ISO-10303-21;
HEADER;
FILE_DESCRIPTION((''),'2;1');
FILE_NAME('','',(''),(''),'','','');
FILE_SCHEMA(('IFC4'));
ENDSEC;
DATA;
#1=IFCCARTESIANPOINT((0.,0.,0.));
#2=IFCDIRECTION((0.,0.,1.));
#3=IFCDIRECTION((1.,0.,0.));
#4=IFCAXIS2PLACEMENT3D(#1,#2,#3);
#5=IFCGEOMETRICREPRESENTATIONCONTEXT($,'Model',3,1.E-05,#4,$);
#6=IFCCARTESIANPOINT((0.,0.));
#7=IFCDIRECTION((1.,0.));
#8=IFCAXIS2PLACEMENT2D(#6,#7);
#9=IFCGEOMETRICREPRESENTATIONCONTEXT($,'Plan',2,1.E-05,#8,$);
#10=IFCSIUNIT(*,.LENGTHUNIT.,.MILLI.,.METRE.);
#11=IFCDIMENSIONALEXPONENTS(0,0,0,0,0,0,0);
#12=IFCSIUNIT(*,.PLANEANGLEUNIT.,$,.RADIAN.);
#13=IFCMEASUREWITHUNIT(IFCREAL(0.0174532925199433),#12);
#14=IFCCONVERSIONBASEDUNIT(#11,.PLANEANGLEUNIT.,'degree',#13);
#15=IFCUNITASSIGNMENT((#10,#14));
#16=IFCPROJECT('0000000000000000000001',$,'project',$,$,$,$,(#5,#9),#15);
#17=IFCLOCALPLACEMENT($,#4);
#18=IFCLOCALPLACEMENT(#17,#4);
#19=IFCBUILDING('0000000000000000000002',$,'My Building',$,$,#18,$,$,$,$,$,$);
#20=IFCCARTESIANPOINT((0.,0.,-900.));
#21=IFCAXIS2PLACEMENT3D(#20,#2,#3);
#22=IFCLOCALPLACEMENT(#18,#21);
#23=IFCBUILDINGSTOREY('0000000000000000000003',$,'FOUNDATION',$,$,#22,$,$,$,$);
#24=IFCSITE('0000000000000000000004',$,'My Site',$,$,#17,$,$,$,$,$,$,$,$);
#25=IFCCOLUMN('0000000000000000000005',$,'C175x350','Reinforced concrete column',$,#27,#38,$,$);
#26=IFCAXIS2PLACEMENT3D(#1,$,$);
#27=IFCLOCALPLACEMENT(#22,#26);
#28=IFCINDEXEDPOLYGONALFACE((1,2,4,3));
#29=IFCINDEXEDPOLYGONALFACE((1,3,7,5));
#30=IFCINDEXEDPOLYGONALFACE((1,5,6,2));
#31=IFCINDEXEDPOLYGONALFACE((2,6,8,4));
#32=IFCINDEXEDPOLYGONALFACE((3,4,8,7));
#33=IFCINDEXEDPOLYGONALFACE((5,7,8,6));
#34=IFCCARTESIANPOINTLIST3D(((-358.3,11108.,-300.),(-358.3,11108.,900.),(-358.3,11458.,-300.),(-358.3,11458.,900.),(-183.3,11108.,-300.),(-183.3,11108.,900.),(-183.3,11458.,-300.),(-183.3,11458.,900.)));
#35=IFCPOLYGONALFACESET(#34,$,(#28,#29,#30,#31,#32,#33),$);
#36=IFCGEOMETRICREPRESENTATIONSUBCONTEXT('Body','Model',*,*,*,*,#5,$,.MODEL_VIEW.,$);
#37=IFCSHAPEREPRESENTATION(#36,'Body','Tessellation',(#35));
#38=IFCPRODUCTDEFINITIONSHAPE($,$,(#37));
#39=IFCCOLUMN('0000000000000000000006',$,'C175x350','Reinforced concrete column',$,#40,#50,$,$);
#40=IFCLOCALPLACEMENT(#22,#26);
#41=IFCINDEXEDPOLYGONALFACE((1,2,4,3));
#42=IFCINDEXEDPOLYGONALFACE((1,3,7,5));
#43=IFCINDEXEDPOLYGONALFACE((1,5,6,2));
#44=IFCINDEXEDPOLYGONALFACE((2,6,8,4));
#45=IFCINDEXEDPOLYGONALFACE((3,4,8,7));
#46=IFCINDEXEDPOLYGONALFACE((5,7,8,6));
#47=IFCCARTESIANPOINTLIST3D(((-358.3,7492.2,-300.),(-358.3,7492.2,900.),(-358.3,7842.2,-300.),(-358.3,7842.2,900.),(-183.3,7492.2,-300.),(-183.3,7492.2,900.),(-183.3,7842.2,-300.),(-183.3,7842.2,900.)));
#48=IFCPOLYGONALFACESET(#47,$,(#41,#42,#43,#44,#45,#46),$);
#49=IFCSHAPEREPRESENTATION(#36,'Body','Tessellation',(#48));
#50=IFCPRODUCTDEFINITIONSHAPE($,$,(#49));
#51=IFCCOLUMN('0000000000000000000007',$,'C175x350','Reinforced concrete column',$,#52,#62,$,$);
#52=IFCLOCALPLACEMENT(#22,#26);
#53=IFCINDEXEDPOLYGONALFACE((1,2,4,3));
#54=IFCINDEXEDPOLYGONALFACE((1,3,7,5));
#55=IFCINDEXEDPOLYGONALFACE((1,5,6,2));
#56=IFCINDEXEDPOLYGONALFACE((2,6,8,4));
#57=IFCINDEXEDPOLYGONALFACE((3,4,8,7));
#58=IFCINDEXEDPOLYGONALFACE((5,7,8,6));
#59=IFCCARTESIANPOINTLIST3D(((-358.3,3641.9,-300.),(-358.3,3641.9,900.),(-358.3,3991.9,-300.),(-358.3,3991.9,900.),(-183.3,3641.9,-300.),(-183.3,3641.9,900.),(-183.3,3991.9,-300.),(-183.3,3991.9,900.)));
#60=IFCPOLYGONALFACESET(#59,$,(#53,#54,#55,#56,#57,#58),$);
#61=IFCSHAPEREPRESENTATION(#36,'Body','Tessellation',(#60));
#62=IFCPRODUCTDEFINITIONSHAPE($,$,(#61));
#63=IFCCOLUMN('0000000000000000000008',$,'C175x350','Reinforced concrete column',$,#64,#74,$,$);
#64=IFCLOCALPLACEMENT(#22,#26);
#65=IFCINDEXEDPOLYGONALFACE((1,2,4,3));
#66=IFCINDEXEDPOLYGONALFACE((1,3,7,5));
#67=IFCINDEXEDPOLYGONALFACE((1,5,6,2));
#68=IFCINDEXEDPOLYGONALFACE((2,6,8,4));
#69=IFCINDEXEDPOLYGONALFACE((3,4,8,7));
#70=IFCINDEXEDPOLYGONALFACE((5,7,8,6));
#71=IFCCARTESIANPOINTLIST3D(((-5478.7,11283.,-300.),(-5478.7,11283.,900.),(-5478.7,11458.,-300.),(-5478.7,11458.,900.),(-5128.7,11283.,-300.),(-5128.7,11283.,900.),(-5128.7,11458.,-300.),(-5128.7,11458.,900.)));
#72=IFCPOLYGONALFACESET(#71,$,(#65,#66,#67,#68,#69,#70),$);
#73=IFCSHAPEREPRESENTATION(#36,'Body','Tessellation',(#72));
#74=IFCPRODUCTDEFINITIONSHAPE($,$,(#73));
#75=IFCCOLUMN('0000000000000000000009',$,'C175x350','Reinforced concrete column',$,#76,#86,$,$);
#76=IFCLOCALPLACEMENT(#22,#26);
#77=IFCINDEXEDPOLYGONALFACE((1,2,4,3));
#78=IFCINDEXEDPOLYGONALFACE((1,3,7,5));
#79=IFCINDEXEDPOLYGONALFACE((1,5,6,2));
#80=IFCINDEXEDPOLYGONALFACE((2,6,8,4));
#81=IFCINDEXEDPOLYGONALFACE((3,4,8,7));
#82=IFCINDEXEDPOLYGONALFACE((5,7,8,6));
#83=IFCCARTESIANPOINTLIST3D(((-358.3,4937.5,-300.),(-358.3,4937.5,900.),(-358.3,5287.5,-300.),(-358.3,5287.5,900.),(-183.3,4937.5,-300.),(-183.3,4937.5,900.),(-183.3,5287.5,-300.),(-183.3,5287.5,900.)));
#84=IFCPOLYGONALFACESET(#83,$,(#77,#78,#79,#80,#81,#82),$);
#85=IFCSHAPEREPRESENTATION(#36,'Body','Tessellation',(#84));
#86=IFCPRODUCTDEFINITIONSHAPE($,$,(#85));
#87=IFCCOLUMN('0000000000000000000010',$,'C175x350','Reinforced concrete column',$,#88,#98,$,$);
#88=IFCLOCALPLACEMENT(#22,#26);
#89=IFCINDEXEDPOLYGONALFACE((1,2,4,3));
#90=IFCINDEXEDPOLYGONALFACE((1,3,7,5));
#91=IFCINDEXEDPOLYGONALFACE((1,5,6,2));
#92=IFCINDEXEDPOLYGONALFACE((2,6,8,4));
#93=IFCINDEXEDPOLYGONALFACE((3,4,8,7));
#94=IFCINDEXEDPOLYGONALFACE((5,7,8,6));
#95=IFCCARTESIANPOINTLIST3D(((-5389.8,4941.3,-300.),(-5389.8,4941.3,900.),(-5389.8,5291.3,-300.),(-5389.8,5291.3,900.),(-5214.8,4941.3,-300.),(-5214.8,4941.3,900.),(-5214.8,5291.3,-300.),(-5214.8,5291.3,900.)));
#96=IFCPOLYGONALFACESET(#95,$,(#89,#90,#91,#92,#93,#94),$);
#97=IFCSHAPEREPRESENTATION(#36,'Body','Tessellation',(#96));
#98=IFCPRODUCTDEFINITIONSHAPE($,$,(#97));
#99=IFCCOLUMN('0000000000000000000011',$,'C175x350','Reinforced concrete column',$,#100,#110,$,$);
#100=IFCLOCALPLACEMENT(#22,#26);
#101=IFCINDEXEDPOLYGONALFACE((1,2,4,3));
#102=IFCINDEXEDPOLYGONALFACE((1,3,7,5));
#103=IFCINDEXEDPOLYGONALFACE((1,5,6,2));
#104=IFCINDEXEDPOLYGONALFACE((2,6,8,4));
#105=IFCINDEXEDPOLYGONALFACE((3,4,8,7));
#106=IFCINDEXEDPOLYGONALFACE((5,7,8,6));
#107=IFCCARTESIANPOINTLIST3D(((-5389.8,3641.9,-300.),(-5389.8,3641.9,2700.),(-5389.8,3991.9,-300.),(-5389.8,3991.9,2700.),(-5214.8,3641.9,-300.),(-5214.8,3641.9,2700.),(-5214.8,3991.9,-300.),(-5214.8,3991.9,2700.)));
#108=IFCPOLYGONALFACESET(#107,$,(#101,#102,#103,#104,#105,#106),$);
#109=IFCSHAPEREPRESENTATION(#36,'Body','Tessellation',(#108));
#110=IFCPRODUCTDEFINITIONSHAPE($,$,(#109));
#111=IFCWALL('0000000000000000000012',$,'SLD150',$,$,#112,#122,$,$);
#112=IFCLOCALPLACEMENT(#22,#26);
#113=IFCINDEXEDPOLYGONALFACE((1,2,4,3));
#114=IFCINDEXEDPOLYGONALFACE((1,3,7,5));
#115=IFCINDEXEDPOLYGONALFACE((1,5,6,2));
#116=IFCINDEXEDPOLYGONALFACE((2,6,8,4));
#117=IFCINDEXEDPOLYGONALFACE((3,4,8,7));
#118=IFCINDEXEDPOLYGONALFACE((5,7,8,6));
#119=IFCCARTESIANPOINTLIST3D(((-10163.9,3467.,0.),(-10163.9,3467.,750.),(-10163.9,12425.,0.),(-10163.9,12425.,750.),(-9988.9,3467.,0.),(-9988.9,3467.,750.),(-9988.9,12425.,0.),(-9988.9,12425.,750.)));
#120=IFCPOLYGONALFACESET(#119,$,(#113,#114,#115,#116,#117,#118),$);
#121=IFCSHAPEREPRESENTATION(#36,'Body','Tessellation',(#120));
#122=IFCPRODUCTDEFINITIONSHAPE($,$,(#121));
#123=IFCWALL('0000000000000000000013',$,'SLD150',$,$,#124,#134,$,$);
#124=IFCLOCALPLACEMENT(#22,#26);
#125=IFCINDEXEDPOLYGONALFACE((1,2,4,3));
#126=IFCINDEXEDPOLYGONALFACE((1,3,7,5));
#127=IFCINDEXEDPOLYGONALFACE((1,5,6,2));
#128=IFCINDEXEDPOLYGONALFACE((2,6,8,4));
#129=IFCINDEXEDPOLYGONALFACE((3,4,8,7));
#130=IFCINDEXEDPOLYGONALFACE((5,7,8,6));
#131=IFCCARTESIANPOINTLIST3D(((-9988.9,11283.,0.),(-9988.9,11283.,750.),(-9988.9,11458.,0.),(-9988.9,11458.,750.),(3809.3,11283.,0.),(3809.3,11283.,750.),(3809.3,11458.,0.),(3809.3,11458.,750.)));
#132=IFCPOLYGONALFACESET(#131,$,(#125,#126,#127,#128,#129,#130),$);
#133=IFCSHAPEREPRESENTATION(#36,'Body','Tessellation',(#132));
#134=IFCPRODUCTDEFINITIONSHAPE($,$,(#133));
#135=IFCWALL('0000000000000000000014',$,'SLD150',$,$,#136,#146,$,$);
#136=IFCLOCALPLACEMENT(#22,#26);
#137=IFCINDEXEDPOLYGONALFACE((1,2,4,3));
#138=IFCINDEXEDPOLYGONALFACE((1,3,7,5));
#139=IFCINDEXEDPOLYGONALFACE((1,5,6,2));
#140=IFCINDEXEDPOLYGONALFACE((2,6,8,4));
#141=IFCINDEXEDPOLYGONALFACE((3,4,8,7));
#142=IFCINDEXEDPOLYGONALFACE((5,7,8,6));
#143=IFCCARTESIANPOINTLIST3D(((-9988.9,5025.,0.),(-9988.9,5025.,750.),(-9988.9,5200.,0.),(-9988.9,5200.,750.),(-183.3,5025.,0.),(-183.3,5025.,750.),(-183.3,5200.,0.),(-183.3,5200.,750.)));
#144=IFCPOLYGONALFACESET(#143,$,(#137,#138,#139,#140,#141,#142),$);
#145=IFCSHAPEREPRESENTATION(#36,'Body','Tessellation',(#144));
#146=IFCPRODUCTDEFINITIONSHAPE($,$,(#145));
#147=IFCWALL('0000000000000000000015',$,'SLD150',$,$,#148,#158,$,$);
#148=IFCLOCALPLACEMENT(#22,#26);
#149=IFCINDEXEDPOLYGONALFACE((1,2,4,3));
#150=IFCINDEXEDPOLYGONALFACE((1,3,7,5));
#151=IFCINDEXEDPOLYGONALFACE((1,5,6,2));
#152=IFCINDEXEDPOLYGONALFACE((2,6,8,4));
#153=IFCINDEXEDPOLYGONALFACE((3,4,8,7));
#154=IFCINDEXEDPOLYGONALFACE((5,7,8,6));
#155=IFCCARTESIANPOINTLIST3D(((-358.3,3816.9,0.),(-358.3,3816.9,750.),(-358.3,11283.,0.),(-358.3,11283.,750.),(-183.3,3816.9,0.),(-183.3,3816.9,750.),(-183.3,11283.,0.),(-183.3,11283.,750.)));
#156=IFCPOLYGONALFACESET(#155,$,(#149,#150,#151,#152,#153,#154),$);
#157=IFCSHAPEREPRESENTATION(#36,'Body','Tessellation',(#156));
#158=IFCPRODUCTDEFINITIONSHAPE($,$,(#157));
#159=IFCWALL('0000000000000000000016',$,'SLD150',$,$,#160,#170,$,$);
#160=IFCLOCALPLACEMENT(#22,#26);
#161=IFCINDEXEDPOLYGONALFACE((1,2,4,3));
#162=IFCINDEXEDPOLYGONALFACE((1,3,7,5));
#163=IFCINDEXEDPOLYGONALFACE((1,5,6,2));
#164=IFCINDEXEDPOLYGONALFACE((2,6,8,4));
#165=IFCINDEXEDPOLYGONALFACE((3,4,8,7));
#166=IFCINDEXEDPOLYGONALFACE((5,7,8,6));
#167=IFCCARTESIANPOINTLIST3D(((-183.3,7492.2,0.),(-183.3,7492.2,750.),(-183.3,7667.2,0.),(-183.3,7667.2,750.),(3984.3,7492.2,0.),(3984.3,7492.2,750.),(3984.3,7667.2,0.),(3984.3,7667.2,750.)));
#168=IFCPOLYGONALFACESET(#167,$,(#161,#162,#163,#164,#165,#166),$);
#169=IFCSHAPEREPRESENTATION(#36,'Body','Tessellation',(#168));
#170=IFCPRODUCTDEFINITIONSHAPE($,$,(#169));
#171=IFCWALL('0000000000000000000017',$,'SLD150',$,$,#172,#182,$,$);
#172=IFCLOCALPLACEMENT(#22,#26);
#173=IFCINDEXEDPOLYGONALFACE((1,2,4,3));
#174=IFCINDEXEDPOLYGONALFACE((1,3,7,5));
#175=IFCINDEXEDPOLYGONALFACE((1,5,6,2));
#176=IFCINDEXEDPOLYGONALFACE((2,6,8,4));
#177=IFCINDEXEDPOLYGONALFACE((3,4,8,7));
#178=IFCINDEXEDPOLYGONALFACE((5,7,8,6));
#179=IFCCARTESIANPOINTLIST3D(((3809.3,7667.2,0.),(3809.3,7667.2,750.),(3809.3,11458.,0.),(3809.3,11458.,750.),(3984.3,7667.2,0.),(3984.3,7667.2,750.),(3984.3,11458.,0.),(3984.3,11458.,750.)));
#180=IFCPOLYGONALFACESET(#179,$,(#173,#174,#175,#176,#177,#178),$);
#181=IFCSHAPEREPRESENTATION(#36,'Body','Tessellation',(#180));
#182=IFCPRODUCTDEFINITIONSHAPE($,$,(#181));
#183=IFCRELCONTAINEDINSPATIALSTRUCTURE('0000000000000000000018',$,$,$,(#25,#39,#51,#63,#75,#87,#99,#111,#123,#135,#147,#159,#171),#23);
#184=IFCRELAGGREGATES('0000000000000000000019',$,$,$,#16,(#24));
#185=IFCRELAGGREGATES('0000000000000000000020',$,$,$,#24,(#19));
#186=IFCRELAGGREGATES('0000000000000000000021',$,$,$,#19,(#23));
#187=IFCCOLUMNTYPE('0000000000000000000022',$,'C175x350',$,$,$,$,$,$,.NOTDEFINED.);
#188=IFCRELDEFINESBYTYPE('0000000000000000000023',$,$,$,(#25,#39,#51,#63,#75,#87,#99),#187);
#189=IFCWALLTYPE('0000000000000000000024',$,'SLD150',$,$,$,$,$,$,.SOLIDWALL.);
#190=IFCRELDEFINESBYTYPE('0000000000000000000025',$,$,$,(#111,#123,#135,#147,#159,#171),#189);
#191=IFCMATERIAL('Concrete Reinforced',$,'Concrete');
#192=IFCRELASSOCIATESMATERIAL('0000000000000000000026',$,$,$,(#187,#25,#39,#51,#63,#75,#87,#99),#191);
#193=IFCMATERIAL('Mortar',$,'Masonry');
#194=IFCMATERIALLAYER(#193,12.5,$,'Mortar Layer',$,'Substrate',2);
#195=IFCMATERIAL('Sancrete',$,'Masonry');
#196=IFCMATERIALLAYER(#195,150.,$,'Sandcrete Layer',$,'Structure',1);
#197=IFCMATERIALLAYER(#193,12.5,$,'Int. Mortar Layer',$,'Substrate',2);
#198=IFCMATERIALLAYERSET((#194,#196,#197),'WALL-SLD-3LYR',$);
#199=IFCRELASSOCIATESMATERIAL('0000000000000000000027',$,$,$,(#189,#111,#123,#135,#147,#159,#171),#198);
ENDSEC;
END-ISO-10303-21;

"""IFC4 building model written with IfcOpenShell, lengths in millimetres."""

from ifc_helpers import new_model, entity, si_unit, converted_unit, frame, origin_with_axes, origin_2d_with_axis, place, context, subcontext, project, spatial, indexed_curve, rectangle, outline, extrude, material, layer, layer_set, layer_usage, material_profile, profile_set, profile_usage, type_object, element, save


model = new_model("IFC4")

# Units and contexts
model_context = context("Model", 3, precision=1e-05, world=origin_with_axes())
plan_context = context("Plan", 2, precision=1e-05, world=origin_2d_with_axis())
body_context = subcontext(model_context, "Body", "Model", "MODEL_VIEW")
ifc_project = project(units=[si_unit("LENGTHUNIT", "METRE", prefix="MILLI"), converted_unit("PLANEANGLEUNIT", "degree", entity("IfcReal", 0.0174532925199433), si_unit("PLANEANGLEUNIT", "RADIAN"), dimensions=[0, 0, 0, 0, 0, 0, 0])], contexts=[model_context, plan_context])

# Site, building, storey
site_placement = place(None, origin_with_axes())
site = spatial("IfcSite", under=ifc_project, at=site_placement, Name="My Site")
building_placement = place(site_placement, origin_with_axes())
building = spatial("IfcBuilding", under=site, at=building_placement, Name="My Building")
storey_placement = place(building_placement, frame((0.0, 0.0, -900.0), z_axis=(0.0, 0.0, 1.0), x_axis=(1.0, 0.0, 0.0)))
storey = spatial("IfcBuildingStorey", under=building, at=storey_placement, Name="FOUNDATION")

# Shared definitions
ifc_material_1 = material(Name="Concrete Reinforced", Category="Concrete")

# Columns
ifc_material_profile = material_profile(ifc_material_1, rectangle(XDim=175.0, YDim=350.0), Name="R. C. Layer", Category="Structure", Priority=1)
ifc_profile_set = profile_set([ifc_material_profile], Name="COL_1LYR")
column_type = type_object("IfcColumnType", Name="C175x350", PredefinedType="NOTDEFINED", material=ifc_profile_set)
ifc_profile_usage_1 = profile_usage(ifc_profile_set, cardinal=5)
column_1_placement = place(storey_placement, frame((-270.8, 11283.0, -300.0), z_axis=(0.0, 0.0, 1.0), x_axis=(1.0, 0.0, 0.0)))
element("IfcColumn", 1, at=column_1_placement, inside=storey, type_object=column_type, material=ifc_profile_usage_1, Name="C175x350", Description="Reinforced concrete column", context=body_context, shape_type="SweptSolid", body=[
    extrude(rectangle(XDim=175.0, YDim=350.0), origin_with_axes(), (0.0, 0.0, 1.0), 1200.0),
])
ifc_profile_usage_2 = profile_usage(ifc_profile_set, cardinal=5)
column_2_placement = place(storey_placement, frame((-270.8, 7667.2, -300.0), z_axis=(0.0, 0.0, 1.0), x_axis=(1.0, 0.0, 0.0)))
element("IfcColumn", 2, at=column_2_placement, inside=storey, type_object=column_type, material=ifc_profile_usage_2, Name="C175x350", Description="Reinforced concrete column", context=body_context, shape_type="SweptSolid", body=[
    extrude(rectangle(XDim=175.0, YDim=350.0), origin_with_axes(), (0.0, 0.0, 1.0), 1200.0),
])
ifc_profile_usage_3 = profile_usage(ifc_profile_set, cardinal=5)
column_3_placement = place(storey_placement, frame((-270.8, 3816.9, -300.0), z_axis=(0.0, 0.0, 1.0), x_axis=(1.0, 0.0, 0.0)))
element("IfcColumn", 3, at=column_3_placement, inside=storey, type_object=column_type, material=ifc_profile_usage_3, Name="C175x350", Description="Reinforced concrete column", context=body_context, shape_type="SweptSolid", body=[
    extrude(rectangle(XDim=175.0, YDim=350.0), origin_with_axes(), (0.0, 0.0, 1.0), 1200.0),
])
ifc_profile_usage_4 = profile_usage(ifc_profile_set, cardinal=5)
column_4_placement = place(storey_placement, frame((-5303.7, 11370.5, -300.0), z_axis=(0.0, 0.0, 1.0), x_axis=(0.0, -1.0, 0.0)))
element("IfcColumn", 4, at=column_4_placement, inside=storey, type_object=column_type, material=ifc_profile_usage_4, Name="C175x350", Description="Reinforced concrete column", context=body_context, shape_type="SweptSolid", body=[
    extrude(rectangle(XDim=175.0, YDim=350.0), origin_with_axes(), (0.0, 0.0, 1.0), 1200.0),
])
ifc_profile_usage_5 = profile_usage(ifc_profile_set, cardinal=5)
column_5_placement = place(storey_placement, frame((-270.8, 5112.5, -300.0), z_axis=(0.0, 0.0, 1.0), x_axis=(1.0, 0.0, 0.0)))
element("IfcColumn", 5, at=column_5_placement, inside=storey, type_object=column_type, material=ifc_profile_usage_5, Name="C175x350", Description="Reinforced concrete column", context=body_context, shape_type="SweptSolid", body=[
    extrude(rectangle(XDim=175.0, YDim=350.0), origin_with_axes(), (0.0, 0.0, 1.0), 1200.0),
])
ifc_profile_usage_6 = profile_usage(ifc_profile_set, cardinal=5)
column_6_placement = place(storey_placement, frame((-5302.3, 5116.3, -300.0), z_axis=(0.0, 0.0, 1.0), x_axis=(1.0, 0.0, 0.0)))
element("IfcColumn", 6, at=column_6_placement, inside=storey, type_object=column_type, material=ifc_profile_usage_6, Name="C175x350", Description="Reinforced concrete column", context=body_context, shape_type="SweptSolid", body=[
    extrude(rectangle(XDim=175.0, YDim=350.0), origin_with_axes(), (0.0, 0.0, 1.0), 1200.0),
])
ifc_profile_usage_7 = profile_usage(ifc_profile_set, cardinal=5)
column_7_placement = place(storey_placement, frame((-5302.3, 3816.9, -300.0), z_axis=(0.0, 0.0, 1.0), x_axis=(1.0, 0.0, 0.0)))
element("IfcColumn", 7, at=column_7_placement, inside=storey, type_object=column_type, material=ifc_profile_usage_7, Name="C175x350", Description="Reinforced concrete column", context=body_context, shape_type="SweptSolid", body=[
    extrude(rectangle(XDim=175.0, YDim=350.0), origin_with_axes(), (0.0, 0.0, 1.0), 3000.0),
])

# Walls
ifc_material_2 = material(Name="Mortar", Category="Masonry")
ifc_layer_1 = layer(ifc_material_2, 12.5, Name="Mortar Layer", Category="Substrate", Priority=2)
ifc_material_3 = material(Name="Sancrete", Category="Masonry")
ifc_layer_2 = layer(ifc_material_3, 150.0, Name="Sandcrete Layer", Category="Structure", Priority=1)
ifc_layer_3 = layer(ifc_material_2, 12.5, Name="Int. Mortar Layer", Category="Substrate", Priority=2)
ifc_layer_set_1 = layer_set([ifc_layer_1, ifc_layer_2, ifc_layer_3], Name="WALL-SLD-3LYR")
ifc_layer_usage_1 = layer_usage(ifc_layer_set_1, "AXIS2", "POSITIVE", 0.0)
wall_type = type_object("IfcWallType", Name="SLD150", PredefinedType="SOLIDWALL", material=ifc_layer_set_1)
wall_1_placement = place(storey_placement, frame((-9988.9, 3467.0, 0.0), z_axis=(0.0, 0.0, 1.0), x_axis=(0.0, 1.0, 0.0)))
element("IfcWall", 8, at=wall_1_placement, inside=storey, type_object=wall_type, material=ifc_layer_usage_1, Name="SLD150", context=body_context, shape_type="SweptSolid", body=[
    extrude(outline(indexed_curve([(0.0, 0.0), (0.0, 175.0), (8958.0, 175.0), (8958.0, 0.0), (0.0, 0.0)], self_intersect=False)), origin_with_axes(), (0.0, 0.0, 1.0), 750.0),
])
ifc_layer_usage_2 = layer_usage(ifc_layer_set_1, "AXIS2", "POSITIVE", 0.0)
wall_2_placement = place(storey_placement, frame((3809.3, 11458.0, 0.0), z_axis=(0.0, 0.0, 1.0), x_axis=(-1.0, 0.0, 0.0)))
element("IfcWall", 9, at=wall_2_placement, inside=storey, type_object=wall_type, material=ifc_layer_usage_2, Name="SLD150", context=body_context, shape_type="SweptSolid", body=[
    extrude(outline(indexed_curve([(0.0, 0.0), (0.0, 175.0), (13798.2, 175.0), (13798.2, 0.0), (0.0, 0.0)], self_intersect=False)), origin_with_axes(), (0.0, 0.0, 1.0), 750.0),
])
ifc_layer_usage_3 = layer_usage(ifc_layer_set_1, "AXIS2", "POSITIVE", 0.0)
wall_3_placement = place(storey_placement, frame((-9988.9, 5025.0, 0.0), z_axis=(0.0, 0.0, 1.0), x_axis=(1.0, -0.000001, 0.0)))
element("IfcWall", 10, at=wall_3_placement, inside=storey, type_object=wall_type, material=ifc_layer_usage_3, Name="SLD150", context=body_context, shape_type="SweptSolid", body=[
    extrude(outline(indexed_curve([(0.0, 0.0), (0.0, 175.0), (9805.7, 175.0), (9805.7, 0.0), (0.0, 0.0)], self_intersect=False)), origin_with_axes(), (0.0, 0.0, 1.0), 750.0),
])
ifc_layer_usage_4 = layer_usage(ifc_layer_set_1, "AXIS2", "POSITIVE", 0.0)
wall_4_placement = place(storey_placement, frame((-358.3, 11283.0, 0.0), z_axis=(0.0, 0.0, 1.0), x_axis=(0.0, -1.0, 0.0)))
element("IfcWall", 11, at=wall_4_placement, inside=storey, type_object=wall_type, material=ifc_layer_usage_4, Name="SLD150", context=body_context, shape_type="SweptSolid", body=[
    extrude(outline(indexed_curve([(0.0, 0.0), (0.0, 175.0), (7466.0, 175.0), (7466.0, 0.0), (0.0, 0.0)], self_intersect=False)), origin_with_axes(), (0.0, 0.0, 1.0), 750.0),
])
ifc_layer_usage_5 = layer_usage(ifc_layer_set_1, "AXIS2", "POSITIVE", 0.0)
wall_5_placement = place(storey_placement, frame((-183.3, 7492.2, 0.0), z_axis=(0.0, 0.0, 1.0), x_axis=(1.0, 0.0, 0.0)))
element("IfcWall", 12, at=wall_5_placement, inside=storey, type_object=wall_type, material=ifc_layer_usage_5, Name="SLD150", context=body_context, shape_type="SweptSolid", body=[
    extrude(outline(indexed_curve([(0.0, 0.0), (0.0, 175.0), (4167.6, 175.0), (4167.6, 0.0), (0.0, 0.0)], self_intersect=False)), origin_with_axes(), (0.0, 0.0, 1.0), 750.0),
])
ifc_layer_usage_6 = layer_usage(ifc_layer_set_1, "AXIS2", "POSITIVE", 0.0)
wall_6_placement = place(storey_placement, frame((3984.3, 7667.2, 0.0), z_axis=(0.0, 0.0, 1.0), x_axis=(0.000001, 1.0, 0.0)))
element("IfcWall", 13, at=wall_6_placement, inside=storey, type_object=wall_type, material=ifc_layer_usage_6, Name="SLD150", context=body_context, shape_type="SweptSolid", body=[
    extrude(outline(indexed_curve([(0.0, 0.0), (0.0, 175.0), (3790.8, 175.0), (3790.8, 0.0), (0.0, 0.0)], self_intersect=False)), origin_with_axes(), (0.0, 0.0, 1.0), 750.0),
])

save(model, "model.ifc")
